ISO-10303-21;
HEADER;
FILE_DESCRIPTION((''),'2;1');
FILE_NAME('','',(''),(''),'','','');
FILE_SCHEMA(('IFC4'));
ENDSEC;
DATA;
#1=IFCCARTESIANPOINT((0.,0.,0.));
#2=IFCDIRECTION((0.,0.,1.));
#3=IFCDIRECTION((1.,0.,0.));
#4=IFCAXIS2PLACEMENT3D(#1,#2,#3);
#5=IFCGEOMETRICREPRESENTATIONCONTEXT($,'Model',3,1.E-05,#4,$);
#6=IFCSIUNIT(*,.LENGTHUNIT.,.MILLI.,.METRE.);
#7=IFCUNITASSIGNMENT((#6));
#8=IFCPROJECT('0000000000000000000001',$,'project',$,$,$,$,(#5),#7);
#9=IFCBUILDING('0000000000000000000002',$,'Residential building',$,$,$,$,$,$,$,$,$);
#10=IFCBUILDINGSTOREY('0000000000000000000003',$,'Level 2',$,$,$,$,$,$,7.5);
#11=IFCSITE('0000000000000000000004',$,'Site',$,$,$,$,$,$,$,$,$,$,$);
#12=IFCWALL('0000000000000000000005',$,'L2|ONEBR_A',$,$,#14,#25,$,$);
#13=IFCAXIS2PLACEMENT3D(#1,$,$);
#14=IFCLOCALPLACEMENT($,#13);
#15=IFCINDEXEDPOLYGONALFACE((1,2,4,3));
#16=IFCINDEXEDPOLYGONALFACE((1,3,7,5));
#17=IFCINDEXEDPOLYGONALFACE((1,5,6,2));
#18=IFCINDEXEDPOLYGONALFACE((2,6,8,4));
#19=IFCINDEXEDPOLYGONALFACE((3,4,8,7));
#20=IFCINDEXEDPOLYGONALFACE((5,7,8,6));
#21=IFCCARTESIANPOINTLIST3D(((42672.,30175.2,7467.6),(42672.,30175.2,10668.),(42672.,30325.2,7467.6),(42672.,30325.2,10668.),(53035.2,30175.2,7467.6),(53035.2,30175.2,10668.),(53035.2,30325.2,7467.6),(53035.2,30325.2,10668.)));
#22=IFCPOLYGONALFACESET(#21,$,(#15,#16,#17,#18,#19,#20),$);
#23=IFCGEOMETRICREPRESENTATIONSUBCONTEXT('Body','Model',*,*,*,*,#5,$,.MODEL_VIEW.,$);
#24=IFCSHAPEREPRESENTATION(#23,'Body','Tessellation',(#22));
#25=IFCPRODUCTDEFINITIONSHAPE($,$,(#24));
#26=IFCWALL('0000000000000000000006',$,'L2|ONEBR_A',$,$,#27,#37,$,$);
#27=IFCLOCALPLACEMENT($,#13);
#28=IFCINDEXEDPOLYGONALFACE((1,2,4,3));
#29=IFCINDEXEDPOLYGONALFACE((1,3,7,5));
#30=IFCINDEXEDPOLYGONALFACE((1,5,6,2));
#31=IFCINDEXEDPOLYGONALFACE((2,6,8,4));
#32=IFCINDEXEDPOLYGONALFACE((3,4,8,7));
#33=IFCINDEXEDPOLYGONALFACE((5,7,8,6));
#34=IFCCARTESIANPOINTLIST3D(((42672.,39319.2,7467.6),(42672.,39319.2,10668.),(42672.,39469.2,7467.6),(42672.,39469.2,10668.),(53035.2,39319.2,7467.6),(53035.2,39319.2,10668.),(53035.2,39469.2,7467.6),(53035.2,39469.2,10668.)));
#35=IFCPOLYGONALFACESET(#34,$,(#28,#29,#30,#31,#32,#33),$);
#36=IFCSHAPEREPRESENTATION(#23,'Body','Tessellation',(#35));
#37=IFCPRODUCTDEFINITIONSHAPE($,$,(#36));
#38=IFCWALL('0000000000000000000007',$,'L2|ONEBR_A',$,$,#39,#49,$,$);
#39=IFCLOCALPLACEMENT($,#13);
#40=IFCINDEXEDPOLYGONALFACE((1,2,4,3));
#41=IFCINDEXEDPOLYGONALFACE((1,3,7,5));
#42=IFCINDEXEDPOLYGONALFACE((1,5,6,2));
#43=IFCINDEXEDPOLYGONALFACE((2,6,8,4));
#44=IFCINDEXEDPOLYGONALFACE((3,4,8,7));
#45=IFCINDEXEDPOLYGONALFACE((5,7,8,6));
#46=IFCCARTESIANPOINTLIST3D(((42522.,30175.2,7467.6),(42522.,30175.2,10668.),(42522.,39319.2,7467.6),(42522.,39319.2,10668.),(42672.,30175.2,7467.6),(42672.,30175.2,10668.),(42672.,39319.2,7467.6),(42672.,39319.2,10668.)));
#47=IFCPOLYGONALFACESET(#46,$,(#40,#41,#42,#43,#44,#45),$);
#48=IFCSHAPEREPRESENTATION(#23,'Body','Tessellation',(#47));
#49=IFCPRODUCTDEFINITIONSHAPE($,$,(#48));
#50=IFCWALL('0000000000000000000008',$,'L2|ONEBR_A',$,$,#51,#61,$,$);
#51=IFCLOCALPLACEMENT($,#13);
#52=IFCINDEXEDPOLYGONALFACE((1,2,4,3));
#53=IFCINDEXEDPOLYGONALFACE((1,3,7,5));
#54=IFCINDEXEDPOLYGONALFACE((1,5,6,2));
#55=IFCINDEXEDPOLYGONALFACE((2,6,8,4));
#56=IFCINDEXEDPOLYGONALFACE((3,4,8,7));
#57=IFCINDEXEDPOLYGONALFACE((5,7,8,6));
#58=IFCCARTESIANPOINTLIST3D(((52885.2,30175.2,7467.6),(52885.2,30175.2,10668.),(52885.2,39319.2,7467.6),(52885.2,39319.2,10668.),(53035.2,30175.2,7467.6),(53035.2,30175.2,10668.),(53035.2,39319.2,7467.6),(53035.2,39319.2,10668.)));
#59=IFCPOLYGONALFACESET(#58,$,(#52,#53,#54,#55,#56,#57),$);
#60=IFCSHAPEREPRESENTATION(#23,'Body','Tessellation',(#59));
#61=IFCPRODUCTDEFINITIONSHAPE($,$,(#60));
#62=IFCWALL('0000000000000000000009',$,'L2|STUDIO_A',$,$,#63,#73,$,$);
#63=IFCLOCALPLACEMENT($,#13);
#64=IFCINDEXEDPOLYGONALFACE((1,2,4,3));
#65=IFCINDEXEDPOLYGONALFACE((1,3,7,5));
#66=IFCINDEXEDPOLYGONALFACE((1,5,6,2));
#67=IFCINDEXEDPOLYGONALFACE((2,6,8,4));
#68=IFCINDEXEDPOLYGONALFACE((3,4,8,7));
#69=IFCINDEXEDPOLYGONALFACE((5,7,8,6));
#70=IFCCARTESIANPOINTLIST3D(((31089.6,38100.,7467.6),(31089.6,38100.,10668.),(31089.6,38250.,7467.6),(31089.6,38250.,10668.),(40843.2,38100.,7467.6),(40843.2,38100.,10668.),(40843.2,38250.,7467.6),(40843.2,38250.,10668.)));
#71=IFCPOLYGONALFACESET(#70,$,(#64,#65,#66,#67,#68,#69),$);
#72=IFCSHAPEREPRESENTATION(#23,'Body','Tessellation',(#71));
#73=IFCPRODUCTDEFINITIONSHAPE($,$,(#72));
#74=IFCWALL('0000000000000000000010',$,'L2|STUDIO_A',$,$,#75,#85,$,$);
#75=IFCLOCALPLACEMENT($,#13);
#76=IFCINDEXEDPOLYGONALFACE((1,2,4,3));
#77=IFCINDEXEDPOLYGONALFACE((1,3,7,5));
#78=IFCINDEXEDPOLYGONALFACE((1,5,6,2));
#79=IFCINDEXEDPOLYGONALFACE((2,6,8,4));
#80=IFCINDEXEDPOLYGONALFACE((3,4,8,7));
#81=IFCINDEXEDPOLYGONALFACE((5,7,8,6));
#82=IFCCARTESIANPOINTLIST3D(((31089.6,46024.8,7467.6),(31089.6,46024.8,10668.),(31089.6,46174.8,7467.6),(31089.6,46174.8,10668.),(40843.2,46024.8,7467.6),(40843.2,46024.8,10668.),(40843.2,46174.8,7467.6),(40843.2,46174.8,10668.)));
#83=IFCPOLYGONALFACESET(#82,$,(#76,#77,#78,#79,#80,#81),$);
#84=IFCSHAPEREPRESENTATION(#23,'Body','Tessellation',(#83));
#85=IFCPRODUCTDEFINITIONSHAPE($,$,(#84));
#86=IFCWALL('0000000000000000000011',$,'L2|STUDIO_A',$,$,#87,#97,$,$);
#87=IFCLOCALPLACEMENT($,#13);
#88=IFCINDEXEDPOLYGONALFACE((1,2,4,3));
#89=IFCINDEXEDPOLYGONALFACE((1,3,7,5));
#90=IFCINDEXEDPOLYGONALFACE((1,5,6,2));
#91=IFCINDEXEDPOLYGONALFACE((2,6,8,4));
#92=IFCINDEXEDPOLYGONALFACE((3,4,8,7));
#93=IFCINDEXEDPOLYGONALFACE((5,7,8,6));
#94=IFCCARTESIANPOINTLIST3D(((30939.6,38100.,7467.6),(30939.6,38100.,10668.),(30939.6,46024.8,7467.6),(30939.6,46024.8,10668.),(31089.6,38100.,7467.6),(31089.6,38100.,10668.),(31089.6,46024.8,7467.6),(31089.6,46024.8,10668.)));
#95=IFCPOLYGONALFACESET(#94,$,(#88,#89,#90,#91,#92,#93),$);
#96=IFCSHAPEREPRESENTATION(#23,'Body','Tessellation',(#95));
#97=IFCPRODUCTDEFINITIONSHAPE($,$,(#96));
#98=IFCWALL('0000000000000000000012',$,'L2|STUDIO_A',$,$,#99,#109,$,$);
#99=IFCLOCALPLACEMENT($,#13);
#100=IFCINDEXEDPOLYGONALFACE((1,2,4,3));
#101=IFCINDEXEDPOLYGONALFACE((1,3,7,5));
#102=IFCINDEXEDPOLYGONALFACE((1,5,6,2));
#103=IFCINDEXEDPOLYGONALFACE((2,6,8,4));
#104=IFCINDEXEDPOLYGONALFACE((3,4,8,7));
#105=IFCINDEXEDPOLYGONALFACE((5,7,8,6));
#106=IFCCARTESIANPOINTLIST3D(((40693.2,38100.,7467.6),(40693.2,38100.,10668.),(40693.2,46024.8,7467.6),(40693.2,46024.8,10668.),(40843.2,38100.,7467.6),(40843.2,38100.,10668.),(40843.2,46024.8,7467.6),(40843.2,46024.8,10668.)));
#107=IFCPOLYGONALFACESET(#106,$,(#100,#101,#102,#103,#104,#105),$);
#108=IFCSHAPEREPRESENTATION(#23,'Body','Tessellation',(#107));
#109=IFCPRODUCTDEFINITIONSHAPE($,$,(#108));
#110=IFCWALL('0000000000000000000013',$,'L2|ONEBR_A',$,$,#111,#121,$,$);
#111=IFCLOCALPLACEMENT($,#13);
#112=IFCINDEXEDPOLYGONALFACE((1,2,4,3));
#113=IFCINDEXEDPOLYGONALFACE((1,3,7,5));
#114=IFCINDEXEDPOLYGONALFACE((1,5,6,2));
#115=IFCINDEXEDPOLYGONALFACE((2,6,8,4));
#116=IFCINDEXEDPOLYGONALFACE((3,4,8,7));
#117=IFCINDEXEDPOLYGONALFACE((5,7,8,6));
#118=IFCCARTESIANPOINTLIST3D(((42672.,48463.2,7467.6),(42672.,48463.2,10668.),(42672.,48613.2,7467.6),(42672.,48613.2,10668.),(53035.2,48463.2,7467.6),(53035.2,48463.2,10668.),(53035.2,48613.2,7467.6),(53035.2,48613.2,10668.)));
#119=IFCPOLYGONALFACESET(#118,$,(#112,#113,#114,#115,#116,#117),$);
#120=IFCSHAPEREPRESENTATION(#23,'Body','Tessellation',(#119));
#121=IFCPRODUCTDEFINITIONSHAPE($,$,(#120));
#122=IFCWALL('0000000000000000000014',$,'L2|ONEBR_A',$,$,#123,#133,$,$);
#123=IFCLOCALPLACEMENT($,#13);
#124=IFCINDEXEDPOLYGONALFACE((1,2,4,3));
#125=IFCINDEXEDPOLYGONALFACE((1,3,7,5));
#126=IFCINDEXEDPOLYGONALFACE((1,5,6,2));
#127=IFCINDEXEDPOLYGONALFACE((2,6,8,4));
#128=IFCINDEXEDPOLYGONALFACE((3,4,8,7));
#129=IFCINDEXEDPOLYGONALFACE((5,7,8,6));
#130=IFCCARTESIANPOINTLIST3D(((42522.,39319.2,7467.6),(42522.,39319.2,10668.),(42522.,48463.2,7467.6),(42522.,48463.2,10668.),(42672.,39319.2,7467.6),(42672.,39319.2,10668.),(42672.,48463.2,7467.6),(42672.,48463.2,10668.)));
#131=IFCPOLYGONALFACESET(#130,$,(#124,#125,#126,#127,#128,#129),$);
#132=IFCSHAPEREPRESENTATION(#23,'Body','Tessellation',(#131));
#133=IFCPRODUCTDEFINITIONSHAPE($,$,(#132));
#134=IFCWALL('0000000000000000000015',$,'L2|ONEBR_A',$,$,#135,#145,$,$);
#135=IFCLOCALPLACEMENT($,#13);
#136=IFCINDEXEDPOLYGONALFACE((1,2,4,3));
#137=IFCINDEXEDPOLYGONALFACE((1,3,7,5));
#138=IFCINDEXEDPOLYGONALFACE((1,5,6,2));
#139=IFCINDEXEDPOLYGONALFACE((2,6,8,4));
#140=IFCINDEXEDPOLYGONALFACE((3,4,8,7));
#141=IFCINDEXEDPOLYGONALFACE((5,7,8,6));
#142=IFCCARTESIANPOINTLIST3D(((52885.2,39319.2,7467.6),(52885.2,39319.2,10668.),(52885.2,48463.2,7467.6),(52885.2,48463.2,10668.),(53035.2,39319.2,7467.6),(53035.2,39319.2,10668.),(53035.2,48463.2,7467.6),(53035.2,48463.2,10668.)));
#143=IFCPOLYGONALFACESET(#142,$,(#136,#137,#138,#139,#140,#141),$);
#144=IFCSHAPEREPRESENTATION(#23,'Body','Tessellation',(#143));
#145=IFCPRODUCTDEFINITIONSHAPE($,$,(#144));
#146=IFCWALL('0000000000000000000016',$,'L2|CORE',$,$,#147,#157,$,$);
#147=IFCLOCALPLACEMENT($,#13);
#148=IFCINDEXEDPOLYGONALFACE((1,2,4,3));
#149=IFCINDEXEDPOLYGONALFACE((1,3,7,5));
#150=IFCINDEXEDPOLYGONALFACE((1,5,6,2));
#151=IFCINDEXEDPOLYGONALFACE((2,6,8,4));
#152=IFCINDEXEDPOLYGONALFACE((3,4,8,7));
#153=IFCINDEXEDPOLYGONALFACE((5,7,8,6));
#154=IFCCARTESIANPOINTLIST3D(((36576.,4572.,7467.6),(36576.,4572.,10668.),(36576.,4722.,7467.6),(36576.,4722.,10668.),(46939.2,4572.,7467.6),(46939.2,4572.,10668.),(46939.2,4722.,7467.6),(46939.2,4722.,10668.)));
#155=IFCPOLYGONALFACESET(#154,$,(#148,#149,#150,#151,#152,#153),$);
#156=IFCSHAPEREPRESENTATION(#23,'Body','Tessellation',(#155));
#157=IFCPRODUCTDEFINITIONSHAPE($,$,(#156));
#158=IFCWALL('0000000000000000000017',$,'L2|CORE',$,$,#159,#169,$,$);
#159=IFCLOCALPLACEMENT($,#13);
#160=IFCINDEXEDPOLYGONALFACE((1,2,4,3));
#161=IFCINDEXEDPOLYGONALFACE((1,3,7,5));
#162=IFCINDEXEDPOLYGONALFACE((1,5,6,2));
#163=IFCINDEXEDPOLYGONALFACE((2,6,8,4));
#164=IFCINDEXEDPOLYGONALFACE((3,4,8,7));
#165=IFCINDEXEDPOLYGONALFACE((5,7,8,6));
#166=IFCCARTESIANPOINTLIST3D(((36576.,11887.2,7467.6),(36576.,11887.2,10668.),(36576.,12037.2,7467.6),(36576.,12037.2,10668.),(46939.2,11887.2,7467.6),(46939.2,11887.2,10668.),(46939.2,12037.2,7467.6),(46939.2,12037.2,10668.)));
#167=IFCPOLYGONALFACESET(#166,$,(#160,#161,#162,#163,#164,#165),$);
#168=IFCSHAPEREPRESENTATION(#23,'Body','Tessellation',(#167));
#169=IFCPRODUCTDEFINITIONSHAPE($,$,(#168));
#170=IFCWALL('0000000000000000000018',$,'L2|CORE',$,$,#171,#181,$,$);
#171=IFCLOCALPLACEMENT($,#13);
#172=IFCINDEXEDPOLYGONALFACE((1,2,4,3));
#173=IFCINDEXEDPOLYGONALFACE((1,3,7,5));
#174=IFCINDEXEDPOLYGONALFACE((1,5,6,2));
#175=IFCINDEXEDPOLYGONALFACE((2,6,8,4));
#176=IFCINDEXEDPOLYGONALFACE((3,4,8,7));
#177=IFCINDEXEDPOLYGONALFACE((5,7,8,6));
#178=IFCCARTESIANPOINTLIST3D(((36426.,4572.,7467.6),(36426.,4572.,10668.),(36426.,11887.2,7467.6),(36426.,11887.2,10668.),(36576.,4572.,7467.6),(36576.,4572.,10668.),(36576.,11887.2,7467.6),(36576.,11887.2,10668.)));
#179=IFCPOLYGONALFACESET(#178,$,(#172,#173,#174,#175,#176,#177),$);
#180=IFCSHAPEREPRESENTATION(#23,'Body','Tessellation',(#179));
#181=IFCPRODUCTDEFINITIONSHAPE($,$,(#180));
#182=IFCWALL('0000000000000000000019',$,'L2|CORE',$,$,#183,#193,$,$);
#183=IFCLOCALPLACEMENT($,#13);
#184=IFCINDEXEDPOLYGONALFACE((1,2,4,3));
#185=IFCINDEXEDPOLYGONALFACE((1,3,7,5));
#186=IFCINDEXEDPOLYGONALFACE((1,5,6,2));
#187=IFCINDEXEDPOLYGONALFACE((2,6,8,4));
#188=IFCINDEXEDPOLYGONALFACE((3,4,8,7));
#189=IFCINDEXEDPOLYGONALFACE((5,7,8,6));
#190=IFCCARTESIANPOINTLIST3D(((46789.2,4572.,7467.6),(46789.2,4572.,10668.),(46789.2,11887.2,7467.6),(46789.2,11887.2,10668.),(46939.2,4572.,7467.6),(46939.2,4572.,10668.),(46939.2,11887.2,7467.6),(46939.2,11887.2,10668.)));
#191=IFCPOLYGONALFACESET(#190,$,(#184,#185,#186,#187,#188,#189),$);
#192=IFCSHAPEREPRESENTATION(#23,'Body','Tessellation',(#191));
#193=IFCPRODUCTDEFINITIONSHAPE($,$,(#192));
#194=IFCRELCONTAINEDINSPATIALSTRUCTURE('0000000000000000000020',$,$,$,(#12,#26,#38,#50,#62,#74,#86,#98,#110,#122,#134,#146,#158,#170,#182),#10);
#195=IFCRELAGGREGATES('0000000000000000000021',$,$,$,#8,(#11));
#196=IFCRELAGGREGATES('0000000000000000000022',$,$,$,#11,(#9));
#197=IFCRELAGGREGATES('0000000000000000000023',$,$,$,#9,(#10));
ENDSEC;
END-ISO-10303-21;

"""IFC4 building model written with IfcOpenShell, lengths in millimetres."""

from ifc_helpers import new_model, si_unit, frame, origin_with_axes, place, context, subcontext, project, spatial, indexed_curve, outline, extrude, element, save


model = new_model("IFC4")

# Units and contexts
model_context = context("Model", 3, precision=1e-05, world=origin_with_axes())
body_context = subcontext(model_context, "Body", "Model", "MODEL_VIEW")
ifc_project = project(units=[si_unit("LENGTHUNIT", "METRE", prefix="MILLI")], contexts=[model_context])

# Site, building, storey
site = spatial("IfcSite", under=ifc_project, Name="Site")
building = spatial("IfcBuilding", under=site, Name="Residential building")
storey = spatial("IfcBuildingStorey", under=building, Name="Level 2", Elevation=7.5)

# Walls
for number, where, z_axis, x_axis, name in (
    (1, (42672.0, 30175.2, 7467.6), (0.0, 0.0, 1.0), (1.0, 0.0, 0.0), "L2|ONEBR_A"),
    (2, (42672.0, 39319.2, 7467.6), (0.0, 0.0, 1.0), (1.0, 0.0, 0.0), "L2|ONEBR_A"),
):
    element("IfcWall", number, at=place(None, frame(where, z_axis=z_axis, x_axis=x_axis)), inside=storey, Name=name, context=body_context, shape_type="SweptSolid", body=[
        extrude(outline(indexed_curve([(0.0, 0.0), (0.0, 150.0), (10363.2, 150.0), (10363.2, 0.0), (0.0, 0.0)], self_intersect=False)), origin_with_axes(), (0.0, 0.0, 1.0), 3200.4),
    ])
for number, where, z_axis, x_axis, name in (
    (3, (42672.0, 30175.2, 7467.6), (0.0, 0.0, 1.0), (0.0, 1.0, 0.0), "L2|ONEBR_A"),
    (4, (53035.2, 30175.2, 7467.6), (0.0, 0.0, 1.0), (0.0, 1.0, 0.0), "L2|ONEBR_A"),
):
    element("IfcWall", number, at=place(None, frame(where, z_axis=z_axis, x_axis=x_axis)), inside=storey, Name=name, context=body_context, shape_type="SweptSolid", body=[
        extrude(outline(indexed_curve([(0.0, 0.0), (0.0, 150.0), (9144.0, 150.0), (9144.0, 0.0), (0.0, 0.0)], self_intersect=False)), origin_with_axes(), (0.0, 0.0, 1.0), 3200.4),
    ])
for number, where, z_axis, x_axis, name in (
    (5, (31089.6, 38100.0, 7467.6), (0.0, 0.0, 1.0), (1.0, 0.0, 0.0), "L2|STUDIO_A"),
    (6, (31089.6, 46024.8, 7467.6), (0.0, 0.0, 1.0), (1.0, 0.0, 0.0), "L2|STUDIO_A"),
):
    element("IfcWall", number, at=place(None, frame(where, z_axis=z_axis, x_axis=x_axis)), inside=storey, Name=name, context=body_context, shape_type="SweptSolid", body=[
        extrude(outline(indexed_curve([(0.0, 0.0), (0.0, 150.0), (9753.6, 150.0), (9753.6, 0.0), (0.0, 0.0)], self_intersect=False)), origin_with_axes(), (0.0, 0.0, 1.0), 3200.4),
    ])
for number, where, z_axis, x_axis, name in (
    (7, (31089.6, 38100.0, 7467.6), (0.0, 0.0, 1.0), (0.0, 1.0, 0.0), "L2|STUDIO_A"),
    (8, (40843.2, 38100.0, 7467.6), (0.0, 0.0, 1.0), (0.0, 1.0, 0.0), "L2|STUDIO_A"),
):
    element("IfcWall", number, at=place(None, frame(where, z_axis=z_axis, x_axis=x_axis)), inside=storey, Name=name, context=body_context, shape_type="SweptSolid", body=[
        extrude(outline(indexed_curve([(0.0, 0.0), (0.0, 150.0), (7924.8, 150.0), (7924.8, 0.0), (0.0, 0.0)], self_intersect=False)), origin_with_axes(), (0.0, 0.0, 1.0), 3200.4),
    ])
for number, where, z_axis, x_axis, name in (
    (9, (42672.0, 48463.2, 7467.6), (0.0, 0.0, 1.0), (1.0, 0.0, 0.0), "L2|ONEBR_A"),
):
    element("IfcWall", number, at=place(None, frame(where, z_axis=z_axis, x_axis=x_axis)), inside=storey, Name=name, context=body_context, shape_type="SweptSolid", body=[
        extrude(outline(indexed_curve([(0.0, 0.0), (0.0, 150.0), (10363.2, 150.0), (10363.2, 0.0), (0.0, 0.0)], self_intersect=False)), origin_with_axes(), (0.0, 0.0, 1.0), 3200.4),
    ])
for number, where, z_axis, x_axis, name in (
    (10, (42672.0, 39319.2, 7467.6), (0.0, 0.0, 1.0), (0.0, 1.0, 0.0), "L2|ONEBR_A"),
    (11, (53035.2, 39319.2, 7467.6), (0.0, 0.0, 1.0), (0.0, 1.0, 0.0), "L2|ONEBR_A"),
):
    element("IfcWall", number, at=place(None, frame(where, z_axis=z_axis, x_axis=x_axis)), inside=storey, Name=name, context=body_context, shape_type="SweptSolid", body=[
        extrude(outline(indexed_curve([(0.0, 0.0), (0.0, 150.0), (9144.0, 150.0), (9144.0, 0.0), (0.0, 0.0)], self_intersect=False)), origin_with_axes(), (0.0, 0.0, 1.0), 3200.4),
    ])
for number, where, z_axis, x_axis, name in (
    (12, (36576.0, 4572.0, 7467.6), (0.0, 0.0, 1.0), (1.0, 0.0, 0.0), "L2|CORE"),
    (13, (36576.0, 11887.2, 7467.6), (0.0, 0.0, 1.0), (1.0, 0.0, 0.0), "L2|CORE"),
):
    element("IfcWall", number, at=place(None, frame(where, z_axis=z_axis, x_axis=x_axis)), inside=storey, Name=name, context=body_context, shape_type="SweptSolid", body=[
        extrude(outline(indexed_curve([(0.0, 0.0), (0.0, 150.0), (10363.2, 150.0), (10363.2, 0.0), (0.0, 0.0)], self_intersect=False)), origin_with_axes(), (0.0, 0.0, 1.0), 3200.4),
    ])
for number, where, z_axis, x_axis, name in (
    (14, (36576.0, 4572.0, 7467.6), (0.0, 0.0, 1.0), (0.0, 1.0, 0.0), "L2|CORE"),
    (15, (46939.2, 4572.0, 7467.6), (0.0, 0.0, 1.0), (0.0, 1.0, 0.0), "L2|CORE"),
):
    element("IfcWall", number, at=place(None, frame(where, z_axis=z_axis, x_axis=x_axis)), inside=storey, Name=name, context=body_context, shape_type="SweptSolid", body=[
        extrude(outline(indexed_curve([(0.0, 0.0), (0.0, 150.0), (7315.2, 150.0), (7315.2, 0.0), (0.0, 0.0)], self_intersect=False)), origin_with_axes(), (0.0, 0.0, 1.0), 3200.4),
    ])

save(model, "model.ifc")
